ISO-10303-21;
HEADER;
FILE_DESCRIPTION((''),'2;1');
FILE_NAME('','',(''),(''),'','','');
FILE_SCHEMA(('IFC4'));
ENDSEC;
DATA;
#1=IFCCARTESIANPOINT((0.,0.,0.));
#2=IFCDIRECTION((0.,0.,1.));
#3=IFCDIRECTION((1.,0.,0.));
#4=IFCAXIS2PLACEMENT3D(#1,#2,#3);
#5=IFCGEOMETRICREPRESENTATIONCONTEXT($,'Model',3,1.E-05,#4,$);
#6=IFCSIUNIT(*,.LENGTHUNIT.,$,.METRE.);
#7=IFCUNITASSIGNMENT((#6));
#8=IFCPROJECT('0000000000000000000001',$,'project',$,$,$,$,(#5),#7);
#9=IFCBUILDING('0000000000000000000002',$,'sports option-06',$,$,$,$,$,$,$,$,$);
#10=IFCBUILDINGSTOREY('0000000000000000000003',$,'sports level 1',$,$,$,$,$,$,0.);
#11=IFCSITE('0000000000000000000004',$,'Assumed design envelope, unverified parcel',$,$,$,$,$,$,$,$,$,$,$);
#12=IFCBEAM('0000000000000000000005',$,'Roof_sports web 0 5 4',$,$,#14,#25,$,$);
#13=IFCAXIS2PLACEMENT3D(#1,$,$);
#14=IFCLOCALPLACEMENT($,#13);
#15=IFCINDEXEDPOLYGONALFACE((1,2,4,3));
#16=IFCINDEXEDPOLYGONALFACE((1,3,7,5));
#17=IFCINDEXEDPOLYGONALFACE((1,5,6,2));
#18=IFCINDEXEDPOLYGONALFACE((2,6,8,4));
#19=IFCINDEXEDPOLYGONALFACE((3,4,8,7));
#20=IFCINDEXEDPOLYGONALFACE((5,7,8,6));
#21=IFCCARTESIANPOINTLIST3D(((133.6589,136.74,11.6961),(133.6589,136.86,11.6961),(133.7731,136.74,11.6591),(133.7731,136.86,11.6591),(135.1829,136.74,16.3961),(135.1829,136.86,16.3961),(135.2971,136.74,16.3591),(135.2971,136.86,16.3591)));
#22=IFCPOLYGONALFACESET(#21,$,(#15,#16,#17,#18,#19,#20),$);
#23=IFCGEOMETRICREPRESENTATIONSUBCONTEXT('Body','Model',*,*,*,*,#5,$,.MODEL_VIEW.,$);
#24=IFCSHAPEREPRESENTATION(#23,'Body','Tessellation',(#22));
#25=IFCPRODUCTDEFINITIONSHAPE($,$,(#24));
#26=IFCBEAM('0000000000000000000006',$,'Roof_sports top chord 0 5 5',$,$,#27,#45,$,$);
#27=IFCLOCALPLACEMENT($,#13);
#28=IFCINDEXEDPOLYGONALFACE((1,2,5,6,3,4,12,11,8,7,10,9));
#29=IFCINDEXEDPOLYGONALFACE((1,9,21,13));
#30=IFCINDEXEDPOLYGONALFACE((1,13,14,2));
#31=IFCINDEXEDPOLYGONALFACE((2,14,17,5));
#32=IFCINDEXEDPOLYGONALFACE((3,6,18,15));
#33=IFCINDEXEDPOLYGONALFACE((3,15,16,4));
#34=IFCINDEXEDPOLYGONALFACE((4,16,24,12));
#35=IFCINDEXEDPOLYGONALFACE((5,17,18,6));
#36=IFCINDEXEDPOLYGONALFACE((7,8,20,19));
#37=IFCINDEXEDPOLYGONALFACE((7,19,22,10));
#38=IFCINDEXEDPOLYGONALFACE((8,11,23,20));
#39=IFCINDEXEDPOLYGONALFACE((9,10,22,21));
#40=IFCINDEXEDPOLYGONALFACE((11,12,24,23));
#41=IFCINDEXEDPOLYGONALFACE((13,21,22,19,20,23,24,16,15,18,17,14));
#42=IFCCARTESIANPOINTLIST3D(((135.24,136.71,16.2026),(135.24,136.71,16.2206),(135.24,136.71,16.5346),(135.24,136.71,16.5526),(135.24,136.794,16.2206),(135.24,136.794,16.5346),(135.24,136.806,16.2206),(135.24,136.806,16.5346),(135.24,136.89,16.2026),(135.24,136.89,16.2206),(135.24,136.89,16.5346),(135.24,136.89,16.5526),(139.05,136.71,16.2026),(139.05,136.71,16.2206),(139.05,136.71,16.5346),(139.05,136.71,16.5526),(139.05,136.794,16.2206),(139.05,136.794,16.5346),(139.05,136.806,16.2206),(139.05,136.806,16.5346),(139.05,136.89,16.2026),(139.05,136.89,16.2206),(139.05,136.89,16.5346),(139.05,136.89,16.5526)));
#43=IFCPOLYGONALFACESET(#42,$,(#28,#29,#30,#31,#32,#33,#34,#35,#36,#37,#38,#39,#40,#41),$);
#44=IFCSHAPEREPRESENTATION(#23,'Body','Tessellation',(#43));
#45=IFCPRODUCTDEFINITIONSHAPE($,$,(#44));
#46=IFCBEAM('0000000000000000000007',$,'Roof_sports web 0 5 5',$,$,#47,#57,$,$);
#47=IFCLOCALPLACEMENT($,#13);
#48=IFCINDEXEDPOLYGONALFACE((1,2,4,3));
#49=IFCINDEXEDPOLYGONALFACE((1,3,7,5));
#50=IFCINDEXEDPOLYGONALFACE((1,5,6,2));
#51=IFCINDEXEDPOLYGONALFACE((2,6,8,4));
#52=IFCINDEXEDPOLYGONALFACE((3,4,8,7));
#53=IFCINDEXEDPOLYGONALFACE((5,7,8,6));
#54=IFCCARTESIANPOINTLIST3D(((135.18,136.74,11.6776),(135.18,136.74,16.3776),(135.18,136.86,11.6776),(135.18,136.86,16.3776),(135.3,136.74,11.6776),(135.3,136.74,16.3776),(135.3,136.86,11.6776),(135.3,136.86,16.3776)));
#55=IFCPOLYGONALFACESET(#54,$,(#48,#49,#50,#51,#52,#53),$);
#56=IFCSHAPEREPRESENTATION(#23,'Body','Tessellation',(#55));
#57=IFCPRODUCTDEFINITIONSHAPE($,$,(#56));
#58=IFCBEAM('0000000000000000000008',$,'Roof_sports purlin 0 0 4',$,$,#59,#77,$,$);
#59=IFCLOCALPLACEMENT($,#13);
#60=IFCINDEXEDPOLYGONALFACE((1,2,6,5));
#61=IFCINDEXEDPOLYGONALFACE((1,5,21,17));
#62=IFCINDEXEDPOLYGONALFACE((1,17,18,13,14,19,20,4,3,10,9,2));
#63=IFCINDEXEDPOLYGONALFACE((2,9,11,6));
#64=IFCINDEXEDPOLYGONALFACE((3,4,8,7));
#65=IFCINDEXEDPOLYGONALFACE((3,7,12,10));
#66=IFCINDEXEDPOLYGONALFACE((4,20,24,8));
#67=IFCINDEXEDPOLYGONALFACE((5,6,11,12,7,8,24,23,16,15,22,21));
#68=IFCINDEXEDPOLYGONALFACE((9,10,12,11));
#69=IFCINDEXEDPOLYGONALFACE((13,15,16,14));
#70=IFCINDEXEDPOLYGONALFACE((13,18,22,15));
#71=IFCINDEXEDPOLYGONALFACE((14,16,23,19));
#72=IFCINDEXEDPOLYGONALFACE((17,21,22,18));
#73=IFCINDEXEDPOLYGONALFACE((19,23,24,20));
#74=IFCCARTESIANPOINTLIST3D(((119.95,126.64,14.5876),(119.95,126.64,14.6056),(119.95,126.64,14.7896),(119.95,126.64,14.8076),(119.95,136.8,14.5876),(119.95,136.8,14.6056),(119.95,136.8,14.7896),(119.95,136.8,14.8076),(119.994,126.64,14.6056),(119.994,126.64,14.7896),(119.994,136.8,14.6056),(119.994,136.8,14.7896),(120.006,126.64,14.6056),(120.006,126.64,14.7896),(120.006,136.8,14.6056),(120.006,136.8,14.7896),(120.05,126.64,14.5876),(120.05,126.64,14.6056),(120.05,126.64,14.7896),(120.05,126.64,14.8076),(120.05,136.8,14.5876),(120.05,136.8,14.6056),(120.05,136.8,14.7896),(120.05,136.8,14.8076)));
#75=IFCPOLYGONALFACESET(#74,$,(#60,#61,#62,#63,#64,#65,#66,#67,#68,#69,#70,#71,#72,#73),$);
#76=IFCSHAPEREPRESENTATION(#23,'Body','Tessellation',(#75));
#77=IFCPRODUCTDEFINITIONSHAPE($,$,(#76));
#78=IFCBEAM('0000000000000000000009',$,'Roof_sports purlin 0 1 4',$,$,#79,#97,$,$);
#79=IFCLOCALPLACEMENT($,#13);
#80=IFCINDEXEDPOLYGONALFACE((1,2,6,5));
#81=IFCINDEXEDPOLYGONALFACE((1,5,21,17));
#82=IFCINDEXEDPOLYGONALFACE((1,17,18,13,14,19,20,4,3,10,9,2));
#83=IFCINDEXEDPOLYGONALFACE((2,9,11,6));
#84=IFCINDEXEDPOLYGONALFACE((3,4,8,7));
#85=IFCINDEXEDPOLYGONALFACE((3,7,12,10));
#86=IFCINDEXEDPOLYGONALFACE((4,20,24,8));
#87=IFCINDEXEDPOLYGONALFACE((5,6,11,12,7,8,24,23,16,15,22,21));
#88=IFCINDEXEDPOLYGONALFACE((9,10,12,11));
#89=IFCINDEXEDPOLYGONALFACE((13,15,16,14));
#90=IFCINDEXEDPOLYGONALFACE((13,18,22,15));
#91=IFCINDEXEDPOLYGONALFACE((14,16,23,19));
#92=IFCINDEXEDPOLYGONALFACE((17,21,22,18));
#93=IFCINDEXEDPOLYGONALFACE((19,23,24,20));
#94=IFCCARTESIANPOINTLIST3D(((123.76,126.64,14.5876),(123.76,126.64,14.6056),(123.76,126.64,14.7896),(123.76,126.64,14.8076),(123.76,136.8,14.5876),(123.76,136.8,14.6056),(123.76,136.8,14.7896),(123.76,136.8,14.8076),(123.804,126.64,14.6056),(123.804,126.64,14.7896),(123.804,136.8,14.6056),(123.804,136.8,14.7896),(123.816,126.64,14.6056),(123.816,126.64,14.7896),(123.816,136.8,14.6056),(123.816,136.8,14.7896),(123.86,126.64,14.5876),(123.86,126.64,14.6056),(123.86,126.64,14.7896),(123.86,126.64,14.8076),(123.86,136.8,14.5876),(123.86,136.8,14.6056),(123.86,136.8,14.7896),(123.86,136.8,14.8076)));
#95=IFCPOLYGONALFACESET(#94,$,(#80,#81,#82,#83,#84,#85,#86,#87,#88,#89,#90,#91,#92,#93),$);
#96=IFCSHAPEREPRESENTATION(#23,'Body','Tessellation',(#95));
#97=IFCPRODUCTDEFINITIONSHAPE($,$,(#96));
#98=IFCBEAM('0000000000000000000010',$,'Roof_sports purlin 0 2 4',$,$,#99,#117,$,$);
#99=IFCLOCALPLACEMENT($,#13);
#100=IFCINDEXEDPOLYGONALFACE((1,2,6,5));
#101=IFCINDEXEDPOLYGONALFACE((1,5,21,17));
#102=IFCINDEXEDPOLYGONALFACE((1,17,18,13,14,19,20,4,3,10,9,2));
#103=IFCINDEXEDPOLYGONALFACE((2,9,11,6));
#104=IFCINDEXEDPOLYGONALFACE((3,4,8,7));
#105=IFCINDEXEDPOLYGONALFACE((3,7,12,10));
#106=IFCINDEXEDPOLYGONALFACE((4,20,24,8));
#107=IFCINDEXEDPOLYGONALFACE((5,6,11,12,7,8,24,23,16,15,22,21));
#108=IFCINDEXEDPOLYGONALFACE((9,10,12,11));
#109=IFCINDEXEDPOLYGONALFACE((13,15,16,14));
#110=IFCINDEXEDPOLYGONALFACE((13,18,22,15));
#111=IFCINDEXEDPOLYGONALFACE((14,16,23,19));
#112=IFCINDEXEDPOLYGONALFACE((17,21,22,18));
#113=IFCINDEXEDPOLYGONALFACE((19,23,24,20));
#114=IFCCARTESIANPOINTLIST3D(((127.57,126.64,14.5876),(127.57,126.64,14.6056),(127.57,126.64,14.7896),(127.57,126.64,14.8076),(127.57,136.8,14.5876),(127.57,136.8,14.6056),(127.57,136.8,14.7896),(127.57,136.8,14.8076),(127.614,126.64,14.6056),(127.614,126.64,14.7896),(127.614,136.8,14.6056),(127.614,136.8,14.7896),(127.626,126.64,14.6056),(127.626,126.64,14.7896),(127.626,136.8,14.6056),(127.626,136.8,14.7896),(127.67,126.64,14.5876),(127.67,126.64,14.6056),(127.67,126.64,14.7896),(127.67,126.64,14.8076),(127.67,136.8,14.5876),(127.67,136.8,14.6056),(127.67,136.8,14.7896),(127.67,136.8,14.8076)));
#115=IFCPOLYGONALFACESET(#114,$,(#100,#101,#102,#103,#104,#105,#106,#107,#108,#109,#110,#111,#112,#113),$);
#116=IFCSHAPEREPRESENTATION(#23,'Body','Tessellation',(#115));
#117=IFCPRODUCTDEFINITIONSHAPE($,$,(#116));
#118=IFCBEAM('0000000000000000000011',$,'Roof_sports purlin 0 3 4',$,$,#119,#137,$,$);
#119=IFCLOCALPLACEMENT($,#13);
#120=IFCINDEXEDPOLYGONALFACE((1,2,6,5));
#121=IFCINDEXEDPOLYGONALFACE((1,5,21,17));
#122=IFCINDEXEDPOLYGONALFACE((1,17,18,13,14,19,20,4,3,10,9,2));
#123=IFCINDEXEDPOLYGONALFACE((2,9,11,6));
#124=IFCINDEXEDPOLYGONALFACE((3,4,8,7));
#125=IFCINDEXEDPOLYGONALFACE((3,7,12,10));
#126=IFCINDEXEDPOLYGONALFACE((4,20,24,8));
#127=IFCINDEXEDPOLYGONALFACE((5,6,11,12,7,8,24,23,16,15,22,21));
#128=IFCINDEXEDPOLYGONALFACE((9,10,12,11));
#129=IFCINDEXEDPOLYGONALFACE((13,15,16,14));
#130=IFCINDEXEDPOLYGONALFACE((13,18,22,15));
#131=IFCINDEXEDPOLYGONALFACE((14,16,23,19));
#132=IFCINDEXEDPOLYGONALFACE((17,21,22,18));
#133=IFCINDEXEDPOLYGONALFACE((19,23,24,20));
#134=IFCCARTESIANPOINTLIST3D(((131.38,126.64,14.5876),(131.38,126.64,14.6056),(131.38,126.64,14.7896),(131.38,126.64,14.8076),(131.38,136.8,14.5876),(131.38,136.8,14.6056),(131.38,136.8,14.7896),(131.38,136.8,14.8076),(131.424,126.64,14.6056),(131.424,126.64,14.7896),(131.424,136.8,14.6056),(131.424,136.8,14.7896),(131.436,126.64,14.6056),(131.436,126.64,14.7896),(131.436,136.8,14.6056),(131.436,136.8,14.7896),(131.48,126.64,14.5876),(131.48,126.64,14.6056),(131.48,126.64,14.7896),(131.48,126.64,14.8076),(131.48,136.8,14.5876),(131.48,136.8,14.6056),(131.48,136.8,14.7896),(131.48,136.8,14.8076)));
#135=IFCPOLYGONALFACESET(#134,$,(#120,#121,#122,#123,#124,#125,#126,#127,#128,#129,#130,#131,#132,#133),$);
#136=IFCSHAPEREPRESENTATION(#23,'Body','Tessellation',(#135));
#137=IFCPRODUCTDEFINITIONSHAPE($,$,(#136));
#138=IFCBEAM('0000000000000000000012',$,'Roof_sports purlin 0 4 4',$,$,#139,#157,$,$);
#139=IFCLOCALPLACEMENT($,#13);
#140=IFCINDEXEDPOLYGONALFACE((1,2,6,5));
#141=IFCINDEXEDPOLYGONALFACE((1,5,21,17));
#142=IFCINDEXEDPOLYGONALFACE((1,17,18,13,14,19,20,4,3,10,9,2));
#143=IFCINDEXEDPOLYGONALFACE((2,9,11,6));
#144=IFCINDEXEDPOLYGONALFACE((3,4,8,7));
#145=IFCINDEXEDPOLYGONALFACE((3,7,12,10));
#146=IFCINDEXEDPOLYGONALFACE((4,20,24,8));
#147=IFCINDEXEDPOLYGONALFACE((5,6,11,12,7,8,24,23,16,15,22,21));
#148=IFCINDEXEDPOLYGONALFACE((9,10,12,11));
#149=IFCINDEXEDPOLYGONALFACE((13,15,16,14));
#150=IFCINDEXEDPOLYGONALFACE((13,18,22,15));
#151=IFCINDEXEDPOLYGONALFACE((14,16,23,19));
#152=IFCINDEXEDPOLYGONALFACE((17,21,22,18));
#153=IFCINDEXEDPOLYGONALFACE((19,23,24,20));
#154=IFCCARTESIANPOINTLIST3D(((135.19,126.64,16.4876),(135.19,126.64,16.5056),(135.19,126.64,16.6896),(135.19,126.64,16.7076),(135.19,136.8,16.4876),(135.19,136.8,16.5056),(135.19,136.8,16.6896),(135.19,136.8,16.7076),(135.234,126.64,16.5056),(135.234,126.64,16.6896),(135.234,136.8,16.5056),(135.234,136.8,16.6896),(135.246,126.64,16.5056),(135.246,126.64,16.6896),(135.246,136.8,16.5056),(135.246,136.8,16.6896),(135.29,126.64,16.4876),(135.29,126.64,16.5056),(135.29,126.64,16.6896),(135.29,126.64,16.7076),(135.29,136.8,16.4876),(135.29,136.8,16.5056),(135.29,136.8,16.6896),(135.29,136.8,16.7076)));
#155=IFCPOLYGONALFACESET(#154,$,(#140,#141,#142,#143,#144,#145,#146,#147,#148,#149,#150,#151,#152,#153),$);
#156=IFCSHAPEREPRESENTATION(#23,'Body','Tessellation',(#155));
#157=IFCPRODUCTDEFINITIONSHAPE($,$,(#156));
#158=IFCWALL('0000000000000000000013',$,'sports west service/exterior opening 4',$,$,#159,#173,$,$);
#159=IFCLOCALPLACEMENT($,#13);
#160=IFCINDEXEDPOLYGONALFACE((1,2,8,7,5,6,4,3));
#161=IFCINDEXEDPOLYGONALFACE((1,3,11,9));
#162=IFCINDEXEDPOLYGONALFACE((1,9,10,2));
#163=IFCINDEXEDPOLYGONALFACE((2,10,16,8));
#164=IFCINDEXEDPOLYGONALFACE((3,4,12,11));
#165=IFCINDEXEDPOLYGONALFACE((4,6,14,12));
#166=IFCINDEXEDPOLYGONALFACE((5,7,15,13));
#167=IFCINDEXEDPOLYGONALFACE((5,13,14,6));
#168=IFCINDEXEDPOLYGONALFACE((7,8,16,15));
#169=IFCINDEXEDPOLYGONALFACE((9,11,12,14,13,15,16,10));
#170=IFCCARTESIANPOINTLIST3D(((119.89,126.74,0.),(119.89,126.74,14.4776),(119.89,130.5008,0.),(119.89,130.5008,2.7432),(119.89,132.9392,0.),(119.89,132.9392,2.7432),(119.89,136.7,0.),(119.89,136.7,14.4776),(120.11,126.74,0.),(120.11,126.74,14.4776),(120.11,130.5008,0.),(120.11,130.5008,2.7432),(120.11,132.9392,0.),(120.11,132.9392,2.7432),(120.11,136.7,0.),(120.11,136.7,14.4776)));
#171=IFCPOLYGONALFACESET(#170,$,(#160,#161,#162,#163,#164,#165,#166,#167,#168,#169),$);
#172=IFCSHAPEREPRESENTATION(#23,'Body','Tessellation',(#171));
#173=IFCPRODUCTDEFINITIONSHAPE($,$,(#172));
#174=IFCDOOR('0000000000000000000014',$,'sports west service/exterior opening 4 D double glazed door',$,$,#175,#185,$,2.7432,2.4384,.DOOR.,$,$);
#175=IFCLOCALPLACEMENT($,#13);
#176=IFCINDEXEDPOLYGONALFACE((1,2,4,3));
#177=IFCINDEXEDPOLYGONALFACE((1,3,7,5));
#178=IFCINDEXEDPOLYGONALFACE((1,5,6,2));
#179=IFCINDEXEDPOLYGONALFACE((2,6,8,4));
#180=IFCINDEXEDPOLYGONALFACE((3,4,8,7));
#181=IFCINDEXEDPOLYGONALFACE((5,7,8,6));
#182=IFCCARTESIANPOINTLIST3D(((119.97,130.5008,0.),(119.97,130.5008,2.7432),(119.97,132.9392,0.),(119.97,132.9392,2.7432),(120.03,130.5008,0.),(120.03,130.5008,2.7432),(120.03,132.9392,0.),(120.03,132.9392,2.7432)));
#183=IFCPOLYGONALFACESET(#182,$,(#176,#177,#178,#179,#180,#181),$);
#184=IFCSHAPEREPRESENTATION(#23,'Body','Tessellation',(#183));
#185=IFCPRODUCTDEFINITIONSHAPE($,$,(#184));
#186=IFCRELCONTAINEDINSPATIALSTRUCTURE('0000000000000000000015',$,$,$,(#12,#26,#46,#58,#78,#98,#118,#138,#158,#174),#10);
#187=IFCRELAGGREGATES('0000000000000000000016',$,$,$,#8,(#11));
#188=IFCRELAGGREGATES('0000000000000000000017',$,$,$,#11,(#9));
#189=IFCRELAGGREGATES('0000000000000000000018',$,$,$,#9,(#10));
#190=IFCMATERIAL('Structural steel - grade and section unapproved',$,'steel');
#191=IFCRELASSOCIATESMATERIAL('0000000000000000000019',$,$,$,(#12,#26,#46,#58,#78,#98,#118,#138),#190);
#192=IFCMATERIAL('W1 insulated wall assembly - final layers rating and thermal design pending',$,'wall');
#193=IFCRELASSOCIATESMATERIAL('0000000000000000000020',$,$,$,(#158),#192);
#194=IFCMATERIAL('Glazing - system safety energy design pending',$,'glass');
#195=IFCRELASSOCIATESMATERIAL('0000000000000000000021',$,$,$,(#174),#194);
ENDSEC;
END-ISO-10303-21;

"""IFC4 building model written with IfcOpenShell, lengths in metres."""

from ifc_helpers import new_model, si_unit, frame, origin_with_axes, place, context, subcontext, project, spatial, rectangle, i_section, extrude, material, element, fill, save


model = new_model("IFC4")

# Units and contexts
model_context = context("Model", 3, precision=1e-05, world=origin_with_axes())
body_context = subcontext(model_context, "Body", "Model", "MODEL_VIEW")
ifc_project = project(units=[si_unit("LENGTHUNIT", "METRE")], contexts=[model_context])

# Site, building, storey
site = spatial("IfcSite", under=ifc_project, Name="Assumed design envelope, unverified parcel")
building = spatial("IfcBuilding", under=site, Name="sports option-06")
storey = spatial("IfcBuildingStorey", under=building, Name="sports level 1", Elevation=0.0)

# Shared definitions
ifc_material_1 = material(Name="Structural steel - grade and section unapproved", Category="steel")

# Beams
beam_1_placement = place(None, frame((133.716, 136.8, 11.6776), z_axis=(0.308446, 0.0, 0.951242), x_axis=(0.0, 1.0, 0.0)))
element("IfcBeam", 1, at=beam_1_placement, inside=storey, material=ifc_material_1, Name="Roof_sports web 0 5 4", context=body_context, shape_type="SweptSolid", body=[
    extrude(rectangle(XDim=0.12, YDim=0.12), origin_with_axes(), (0.0, 0.0, 1.0), 4.9409),
])
beam_2_placement = place(None, frame((135.24, 136.8, 16.3776), z_axis=(1.0, 0.0, 0.0), x_axis=(0.0, 1.0, 0.0)))
element("IfcBeam", 2, at=beam_2_placement, inside=storey, material=ifc_material_1, Name="Roof_sports top chord 0 5 5", context=body_context, shape_type="SweptSolid", body=[
    extrude(i_section(OverallWidth=0.18, OverallDepth=0.35, WebThickness=0.012, FlangeThickness=0.018, FilletRadius=0.0), origin_with_axes(), (0.0, 0.0, 1.0), 3.81),
])
beam_3_placement = place(None, frame((135.24, 136.8, 11.6776), z_axis=(0.0, 0.0, 1.0), x_axis=(-1.0, 0.0, 0.0)))
element("IfcBeam", 3, at=beam_3_placement, inside=storey, material=ifc_material_1, Name="Roof_sports web 0 5 5", context=body_context, shape_type="SweptSolid", body=[
    extrude(rectangle(XDim=0.12, YDim=0.12), origin_with_axes(), (0.0, 0.0, 1.0), 4.7),
])
for number, where, z_axis, x_axis, name in (
    (4, (120.0, 126.64, 14.6976), (0.0, 1.0, 0.0), (-1.0, 0.0, 0.0), "Roof_sports purlin 0 0 4"),
    (5, (123.81, 126.64, 14.6976), (0.0, 1.0, 0.0), (-1.0, 0.0, 0.0), "Roof_sports purlin 0 1 4"),
    (6, (127.62, 126.64, 14.6976), (0.0, 1.0, 0.0), (-1.0, 0.0, 0.0), "Roof_sports purlin 0 2 4"),
    (7, (131.43, 126.64, 14.6976), (0.0, 1.0, 0.0), (-1.0, 0.0, 0.0), "Roof_sports purlin 0 3 4"),
    (8, (135.24, 126.64, 16.5976), (0.0, 1.0, 0.0), (-1.0, 0.0, 0.0), "Roof_sports purlin 0 4 4"),
):
    element("IfcBeam", number, at=place(None, frame(where, z_axis=z_axis, x_axis=x_axis)), inside=storey, material=ifc_material_1, Name=name, context=body_context, shape_type="SweptSolid", body=[
        extrude(i_section(OverallWidth=0.1, OverallDepth=0.22, WebThickness=0.012, FlangeThickness=0.018, FilletRadius=0.0), origin_with_axes(), (0.0, 0.0, 1.0), 10.16),
    ])

# Wall, opening, door
ifc_material_2 = material(Name="W1 insulated wall assembly - final layers rating and thermal design pending", Category="wall")
wall_placement = place(None, frame((120.0, 131.72, 0.0), z_axis=(0.0, 0.0, 1.0), x_axis=(0.0, 1.0, 0.0)))
wall = element("IfcWall", 9, at=wall_placement, inside=storey, material=ifc_material_2, Name="sports west service/exterior opening 4", context=body_context, shape_type="SweptSolid", body=[
    extrude(rectangle(XDim=9.96, YDim=0.22), origin_with_axes(), (0.0, 0.0, 1.0), 14.4776),
])
opening_placement = place(None, frame((120.0, 131.72, 0.0), z_axis=(0.0, 0.0, 1.0), x_axis=(0.0, 1.0, 0.0)))
opening = element("IfcOpeningElement", 10, at=opening_placement, cuts=wall, context=body_context, shape_type="SweptSolid", body=[
    extrude(rectangle(XDim=2.4384, YDim=0.32), origin_with_axes(), (0.0, 0.0, 1.0), 2.7432),
])
ifc_material_3 = material(Name="Glazing - system safety energy design pending", Category="glass")
door_placement = place(None, frame((120.0, 131.72, 0.0), z_axis=(0.0, 0.0, 1.0), x_axis=(0.0, 1.0, 0.0)))
door = element("IfcDoor", 11, at=door_placement, inside=storey, material=ifc_material_3, Name="sports west service/exterior opening 4 D double glazed door", OverallHeight=2.7432, OverallWidth=2.4384, PredefinedType="DOOR", context=body_context, shape_type="SweptSolid", body=[
    extrude(rectangle(XDim=2.4384, YDim=0.06), origin_with_axes(), (0.0, 0.0, 1.0), 2.7432),
])
fill(opening, door)

save(model, "model.ifc")
